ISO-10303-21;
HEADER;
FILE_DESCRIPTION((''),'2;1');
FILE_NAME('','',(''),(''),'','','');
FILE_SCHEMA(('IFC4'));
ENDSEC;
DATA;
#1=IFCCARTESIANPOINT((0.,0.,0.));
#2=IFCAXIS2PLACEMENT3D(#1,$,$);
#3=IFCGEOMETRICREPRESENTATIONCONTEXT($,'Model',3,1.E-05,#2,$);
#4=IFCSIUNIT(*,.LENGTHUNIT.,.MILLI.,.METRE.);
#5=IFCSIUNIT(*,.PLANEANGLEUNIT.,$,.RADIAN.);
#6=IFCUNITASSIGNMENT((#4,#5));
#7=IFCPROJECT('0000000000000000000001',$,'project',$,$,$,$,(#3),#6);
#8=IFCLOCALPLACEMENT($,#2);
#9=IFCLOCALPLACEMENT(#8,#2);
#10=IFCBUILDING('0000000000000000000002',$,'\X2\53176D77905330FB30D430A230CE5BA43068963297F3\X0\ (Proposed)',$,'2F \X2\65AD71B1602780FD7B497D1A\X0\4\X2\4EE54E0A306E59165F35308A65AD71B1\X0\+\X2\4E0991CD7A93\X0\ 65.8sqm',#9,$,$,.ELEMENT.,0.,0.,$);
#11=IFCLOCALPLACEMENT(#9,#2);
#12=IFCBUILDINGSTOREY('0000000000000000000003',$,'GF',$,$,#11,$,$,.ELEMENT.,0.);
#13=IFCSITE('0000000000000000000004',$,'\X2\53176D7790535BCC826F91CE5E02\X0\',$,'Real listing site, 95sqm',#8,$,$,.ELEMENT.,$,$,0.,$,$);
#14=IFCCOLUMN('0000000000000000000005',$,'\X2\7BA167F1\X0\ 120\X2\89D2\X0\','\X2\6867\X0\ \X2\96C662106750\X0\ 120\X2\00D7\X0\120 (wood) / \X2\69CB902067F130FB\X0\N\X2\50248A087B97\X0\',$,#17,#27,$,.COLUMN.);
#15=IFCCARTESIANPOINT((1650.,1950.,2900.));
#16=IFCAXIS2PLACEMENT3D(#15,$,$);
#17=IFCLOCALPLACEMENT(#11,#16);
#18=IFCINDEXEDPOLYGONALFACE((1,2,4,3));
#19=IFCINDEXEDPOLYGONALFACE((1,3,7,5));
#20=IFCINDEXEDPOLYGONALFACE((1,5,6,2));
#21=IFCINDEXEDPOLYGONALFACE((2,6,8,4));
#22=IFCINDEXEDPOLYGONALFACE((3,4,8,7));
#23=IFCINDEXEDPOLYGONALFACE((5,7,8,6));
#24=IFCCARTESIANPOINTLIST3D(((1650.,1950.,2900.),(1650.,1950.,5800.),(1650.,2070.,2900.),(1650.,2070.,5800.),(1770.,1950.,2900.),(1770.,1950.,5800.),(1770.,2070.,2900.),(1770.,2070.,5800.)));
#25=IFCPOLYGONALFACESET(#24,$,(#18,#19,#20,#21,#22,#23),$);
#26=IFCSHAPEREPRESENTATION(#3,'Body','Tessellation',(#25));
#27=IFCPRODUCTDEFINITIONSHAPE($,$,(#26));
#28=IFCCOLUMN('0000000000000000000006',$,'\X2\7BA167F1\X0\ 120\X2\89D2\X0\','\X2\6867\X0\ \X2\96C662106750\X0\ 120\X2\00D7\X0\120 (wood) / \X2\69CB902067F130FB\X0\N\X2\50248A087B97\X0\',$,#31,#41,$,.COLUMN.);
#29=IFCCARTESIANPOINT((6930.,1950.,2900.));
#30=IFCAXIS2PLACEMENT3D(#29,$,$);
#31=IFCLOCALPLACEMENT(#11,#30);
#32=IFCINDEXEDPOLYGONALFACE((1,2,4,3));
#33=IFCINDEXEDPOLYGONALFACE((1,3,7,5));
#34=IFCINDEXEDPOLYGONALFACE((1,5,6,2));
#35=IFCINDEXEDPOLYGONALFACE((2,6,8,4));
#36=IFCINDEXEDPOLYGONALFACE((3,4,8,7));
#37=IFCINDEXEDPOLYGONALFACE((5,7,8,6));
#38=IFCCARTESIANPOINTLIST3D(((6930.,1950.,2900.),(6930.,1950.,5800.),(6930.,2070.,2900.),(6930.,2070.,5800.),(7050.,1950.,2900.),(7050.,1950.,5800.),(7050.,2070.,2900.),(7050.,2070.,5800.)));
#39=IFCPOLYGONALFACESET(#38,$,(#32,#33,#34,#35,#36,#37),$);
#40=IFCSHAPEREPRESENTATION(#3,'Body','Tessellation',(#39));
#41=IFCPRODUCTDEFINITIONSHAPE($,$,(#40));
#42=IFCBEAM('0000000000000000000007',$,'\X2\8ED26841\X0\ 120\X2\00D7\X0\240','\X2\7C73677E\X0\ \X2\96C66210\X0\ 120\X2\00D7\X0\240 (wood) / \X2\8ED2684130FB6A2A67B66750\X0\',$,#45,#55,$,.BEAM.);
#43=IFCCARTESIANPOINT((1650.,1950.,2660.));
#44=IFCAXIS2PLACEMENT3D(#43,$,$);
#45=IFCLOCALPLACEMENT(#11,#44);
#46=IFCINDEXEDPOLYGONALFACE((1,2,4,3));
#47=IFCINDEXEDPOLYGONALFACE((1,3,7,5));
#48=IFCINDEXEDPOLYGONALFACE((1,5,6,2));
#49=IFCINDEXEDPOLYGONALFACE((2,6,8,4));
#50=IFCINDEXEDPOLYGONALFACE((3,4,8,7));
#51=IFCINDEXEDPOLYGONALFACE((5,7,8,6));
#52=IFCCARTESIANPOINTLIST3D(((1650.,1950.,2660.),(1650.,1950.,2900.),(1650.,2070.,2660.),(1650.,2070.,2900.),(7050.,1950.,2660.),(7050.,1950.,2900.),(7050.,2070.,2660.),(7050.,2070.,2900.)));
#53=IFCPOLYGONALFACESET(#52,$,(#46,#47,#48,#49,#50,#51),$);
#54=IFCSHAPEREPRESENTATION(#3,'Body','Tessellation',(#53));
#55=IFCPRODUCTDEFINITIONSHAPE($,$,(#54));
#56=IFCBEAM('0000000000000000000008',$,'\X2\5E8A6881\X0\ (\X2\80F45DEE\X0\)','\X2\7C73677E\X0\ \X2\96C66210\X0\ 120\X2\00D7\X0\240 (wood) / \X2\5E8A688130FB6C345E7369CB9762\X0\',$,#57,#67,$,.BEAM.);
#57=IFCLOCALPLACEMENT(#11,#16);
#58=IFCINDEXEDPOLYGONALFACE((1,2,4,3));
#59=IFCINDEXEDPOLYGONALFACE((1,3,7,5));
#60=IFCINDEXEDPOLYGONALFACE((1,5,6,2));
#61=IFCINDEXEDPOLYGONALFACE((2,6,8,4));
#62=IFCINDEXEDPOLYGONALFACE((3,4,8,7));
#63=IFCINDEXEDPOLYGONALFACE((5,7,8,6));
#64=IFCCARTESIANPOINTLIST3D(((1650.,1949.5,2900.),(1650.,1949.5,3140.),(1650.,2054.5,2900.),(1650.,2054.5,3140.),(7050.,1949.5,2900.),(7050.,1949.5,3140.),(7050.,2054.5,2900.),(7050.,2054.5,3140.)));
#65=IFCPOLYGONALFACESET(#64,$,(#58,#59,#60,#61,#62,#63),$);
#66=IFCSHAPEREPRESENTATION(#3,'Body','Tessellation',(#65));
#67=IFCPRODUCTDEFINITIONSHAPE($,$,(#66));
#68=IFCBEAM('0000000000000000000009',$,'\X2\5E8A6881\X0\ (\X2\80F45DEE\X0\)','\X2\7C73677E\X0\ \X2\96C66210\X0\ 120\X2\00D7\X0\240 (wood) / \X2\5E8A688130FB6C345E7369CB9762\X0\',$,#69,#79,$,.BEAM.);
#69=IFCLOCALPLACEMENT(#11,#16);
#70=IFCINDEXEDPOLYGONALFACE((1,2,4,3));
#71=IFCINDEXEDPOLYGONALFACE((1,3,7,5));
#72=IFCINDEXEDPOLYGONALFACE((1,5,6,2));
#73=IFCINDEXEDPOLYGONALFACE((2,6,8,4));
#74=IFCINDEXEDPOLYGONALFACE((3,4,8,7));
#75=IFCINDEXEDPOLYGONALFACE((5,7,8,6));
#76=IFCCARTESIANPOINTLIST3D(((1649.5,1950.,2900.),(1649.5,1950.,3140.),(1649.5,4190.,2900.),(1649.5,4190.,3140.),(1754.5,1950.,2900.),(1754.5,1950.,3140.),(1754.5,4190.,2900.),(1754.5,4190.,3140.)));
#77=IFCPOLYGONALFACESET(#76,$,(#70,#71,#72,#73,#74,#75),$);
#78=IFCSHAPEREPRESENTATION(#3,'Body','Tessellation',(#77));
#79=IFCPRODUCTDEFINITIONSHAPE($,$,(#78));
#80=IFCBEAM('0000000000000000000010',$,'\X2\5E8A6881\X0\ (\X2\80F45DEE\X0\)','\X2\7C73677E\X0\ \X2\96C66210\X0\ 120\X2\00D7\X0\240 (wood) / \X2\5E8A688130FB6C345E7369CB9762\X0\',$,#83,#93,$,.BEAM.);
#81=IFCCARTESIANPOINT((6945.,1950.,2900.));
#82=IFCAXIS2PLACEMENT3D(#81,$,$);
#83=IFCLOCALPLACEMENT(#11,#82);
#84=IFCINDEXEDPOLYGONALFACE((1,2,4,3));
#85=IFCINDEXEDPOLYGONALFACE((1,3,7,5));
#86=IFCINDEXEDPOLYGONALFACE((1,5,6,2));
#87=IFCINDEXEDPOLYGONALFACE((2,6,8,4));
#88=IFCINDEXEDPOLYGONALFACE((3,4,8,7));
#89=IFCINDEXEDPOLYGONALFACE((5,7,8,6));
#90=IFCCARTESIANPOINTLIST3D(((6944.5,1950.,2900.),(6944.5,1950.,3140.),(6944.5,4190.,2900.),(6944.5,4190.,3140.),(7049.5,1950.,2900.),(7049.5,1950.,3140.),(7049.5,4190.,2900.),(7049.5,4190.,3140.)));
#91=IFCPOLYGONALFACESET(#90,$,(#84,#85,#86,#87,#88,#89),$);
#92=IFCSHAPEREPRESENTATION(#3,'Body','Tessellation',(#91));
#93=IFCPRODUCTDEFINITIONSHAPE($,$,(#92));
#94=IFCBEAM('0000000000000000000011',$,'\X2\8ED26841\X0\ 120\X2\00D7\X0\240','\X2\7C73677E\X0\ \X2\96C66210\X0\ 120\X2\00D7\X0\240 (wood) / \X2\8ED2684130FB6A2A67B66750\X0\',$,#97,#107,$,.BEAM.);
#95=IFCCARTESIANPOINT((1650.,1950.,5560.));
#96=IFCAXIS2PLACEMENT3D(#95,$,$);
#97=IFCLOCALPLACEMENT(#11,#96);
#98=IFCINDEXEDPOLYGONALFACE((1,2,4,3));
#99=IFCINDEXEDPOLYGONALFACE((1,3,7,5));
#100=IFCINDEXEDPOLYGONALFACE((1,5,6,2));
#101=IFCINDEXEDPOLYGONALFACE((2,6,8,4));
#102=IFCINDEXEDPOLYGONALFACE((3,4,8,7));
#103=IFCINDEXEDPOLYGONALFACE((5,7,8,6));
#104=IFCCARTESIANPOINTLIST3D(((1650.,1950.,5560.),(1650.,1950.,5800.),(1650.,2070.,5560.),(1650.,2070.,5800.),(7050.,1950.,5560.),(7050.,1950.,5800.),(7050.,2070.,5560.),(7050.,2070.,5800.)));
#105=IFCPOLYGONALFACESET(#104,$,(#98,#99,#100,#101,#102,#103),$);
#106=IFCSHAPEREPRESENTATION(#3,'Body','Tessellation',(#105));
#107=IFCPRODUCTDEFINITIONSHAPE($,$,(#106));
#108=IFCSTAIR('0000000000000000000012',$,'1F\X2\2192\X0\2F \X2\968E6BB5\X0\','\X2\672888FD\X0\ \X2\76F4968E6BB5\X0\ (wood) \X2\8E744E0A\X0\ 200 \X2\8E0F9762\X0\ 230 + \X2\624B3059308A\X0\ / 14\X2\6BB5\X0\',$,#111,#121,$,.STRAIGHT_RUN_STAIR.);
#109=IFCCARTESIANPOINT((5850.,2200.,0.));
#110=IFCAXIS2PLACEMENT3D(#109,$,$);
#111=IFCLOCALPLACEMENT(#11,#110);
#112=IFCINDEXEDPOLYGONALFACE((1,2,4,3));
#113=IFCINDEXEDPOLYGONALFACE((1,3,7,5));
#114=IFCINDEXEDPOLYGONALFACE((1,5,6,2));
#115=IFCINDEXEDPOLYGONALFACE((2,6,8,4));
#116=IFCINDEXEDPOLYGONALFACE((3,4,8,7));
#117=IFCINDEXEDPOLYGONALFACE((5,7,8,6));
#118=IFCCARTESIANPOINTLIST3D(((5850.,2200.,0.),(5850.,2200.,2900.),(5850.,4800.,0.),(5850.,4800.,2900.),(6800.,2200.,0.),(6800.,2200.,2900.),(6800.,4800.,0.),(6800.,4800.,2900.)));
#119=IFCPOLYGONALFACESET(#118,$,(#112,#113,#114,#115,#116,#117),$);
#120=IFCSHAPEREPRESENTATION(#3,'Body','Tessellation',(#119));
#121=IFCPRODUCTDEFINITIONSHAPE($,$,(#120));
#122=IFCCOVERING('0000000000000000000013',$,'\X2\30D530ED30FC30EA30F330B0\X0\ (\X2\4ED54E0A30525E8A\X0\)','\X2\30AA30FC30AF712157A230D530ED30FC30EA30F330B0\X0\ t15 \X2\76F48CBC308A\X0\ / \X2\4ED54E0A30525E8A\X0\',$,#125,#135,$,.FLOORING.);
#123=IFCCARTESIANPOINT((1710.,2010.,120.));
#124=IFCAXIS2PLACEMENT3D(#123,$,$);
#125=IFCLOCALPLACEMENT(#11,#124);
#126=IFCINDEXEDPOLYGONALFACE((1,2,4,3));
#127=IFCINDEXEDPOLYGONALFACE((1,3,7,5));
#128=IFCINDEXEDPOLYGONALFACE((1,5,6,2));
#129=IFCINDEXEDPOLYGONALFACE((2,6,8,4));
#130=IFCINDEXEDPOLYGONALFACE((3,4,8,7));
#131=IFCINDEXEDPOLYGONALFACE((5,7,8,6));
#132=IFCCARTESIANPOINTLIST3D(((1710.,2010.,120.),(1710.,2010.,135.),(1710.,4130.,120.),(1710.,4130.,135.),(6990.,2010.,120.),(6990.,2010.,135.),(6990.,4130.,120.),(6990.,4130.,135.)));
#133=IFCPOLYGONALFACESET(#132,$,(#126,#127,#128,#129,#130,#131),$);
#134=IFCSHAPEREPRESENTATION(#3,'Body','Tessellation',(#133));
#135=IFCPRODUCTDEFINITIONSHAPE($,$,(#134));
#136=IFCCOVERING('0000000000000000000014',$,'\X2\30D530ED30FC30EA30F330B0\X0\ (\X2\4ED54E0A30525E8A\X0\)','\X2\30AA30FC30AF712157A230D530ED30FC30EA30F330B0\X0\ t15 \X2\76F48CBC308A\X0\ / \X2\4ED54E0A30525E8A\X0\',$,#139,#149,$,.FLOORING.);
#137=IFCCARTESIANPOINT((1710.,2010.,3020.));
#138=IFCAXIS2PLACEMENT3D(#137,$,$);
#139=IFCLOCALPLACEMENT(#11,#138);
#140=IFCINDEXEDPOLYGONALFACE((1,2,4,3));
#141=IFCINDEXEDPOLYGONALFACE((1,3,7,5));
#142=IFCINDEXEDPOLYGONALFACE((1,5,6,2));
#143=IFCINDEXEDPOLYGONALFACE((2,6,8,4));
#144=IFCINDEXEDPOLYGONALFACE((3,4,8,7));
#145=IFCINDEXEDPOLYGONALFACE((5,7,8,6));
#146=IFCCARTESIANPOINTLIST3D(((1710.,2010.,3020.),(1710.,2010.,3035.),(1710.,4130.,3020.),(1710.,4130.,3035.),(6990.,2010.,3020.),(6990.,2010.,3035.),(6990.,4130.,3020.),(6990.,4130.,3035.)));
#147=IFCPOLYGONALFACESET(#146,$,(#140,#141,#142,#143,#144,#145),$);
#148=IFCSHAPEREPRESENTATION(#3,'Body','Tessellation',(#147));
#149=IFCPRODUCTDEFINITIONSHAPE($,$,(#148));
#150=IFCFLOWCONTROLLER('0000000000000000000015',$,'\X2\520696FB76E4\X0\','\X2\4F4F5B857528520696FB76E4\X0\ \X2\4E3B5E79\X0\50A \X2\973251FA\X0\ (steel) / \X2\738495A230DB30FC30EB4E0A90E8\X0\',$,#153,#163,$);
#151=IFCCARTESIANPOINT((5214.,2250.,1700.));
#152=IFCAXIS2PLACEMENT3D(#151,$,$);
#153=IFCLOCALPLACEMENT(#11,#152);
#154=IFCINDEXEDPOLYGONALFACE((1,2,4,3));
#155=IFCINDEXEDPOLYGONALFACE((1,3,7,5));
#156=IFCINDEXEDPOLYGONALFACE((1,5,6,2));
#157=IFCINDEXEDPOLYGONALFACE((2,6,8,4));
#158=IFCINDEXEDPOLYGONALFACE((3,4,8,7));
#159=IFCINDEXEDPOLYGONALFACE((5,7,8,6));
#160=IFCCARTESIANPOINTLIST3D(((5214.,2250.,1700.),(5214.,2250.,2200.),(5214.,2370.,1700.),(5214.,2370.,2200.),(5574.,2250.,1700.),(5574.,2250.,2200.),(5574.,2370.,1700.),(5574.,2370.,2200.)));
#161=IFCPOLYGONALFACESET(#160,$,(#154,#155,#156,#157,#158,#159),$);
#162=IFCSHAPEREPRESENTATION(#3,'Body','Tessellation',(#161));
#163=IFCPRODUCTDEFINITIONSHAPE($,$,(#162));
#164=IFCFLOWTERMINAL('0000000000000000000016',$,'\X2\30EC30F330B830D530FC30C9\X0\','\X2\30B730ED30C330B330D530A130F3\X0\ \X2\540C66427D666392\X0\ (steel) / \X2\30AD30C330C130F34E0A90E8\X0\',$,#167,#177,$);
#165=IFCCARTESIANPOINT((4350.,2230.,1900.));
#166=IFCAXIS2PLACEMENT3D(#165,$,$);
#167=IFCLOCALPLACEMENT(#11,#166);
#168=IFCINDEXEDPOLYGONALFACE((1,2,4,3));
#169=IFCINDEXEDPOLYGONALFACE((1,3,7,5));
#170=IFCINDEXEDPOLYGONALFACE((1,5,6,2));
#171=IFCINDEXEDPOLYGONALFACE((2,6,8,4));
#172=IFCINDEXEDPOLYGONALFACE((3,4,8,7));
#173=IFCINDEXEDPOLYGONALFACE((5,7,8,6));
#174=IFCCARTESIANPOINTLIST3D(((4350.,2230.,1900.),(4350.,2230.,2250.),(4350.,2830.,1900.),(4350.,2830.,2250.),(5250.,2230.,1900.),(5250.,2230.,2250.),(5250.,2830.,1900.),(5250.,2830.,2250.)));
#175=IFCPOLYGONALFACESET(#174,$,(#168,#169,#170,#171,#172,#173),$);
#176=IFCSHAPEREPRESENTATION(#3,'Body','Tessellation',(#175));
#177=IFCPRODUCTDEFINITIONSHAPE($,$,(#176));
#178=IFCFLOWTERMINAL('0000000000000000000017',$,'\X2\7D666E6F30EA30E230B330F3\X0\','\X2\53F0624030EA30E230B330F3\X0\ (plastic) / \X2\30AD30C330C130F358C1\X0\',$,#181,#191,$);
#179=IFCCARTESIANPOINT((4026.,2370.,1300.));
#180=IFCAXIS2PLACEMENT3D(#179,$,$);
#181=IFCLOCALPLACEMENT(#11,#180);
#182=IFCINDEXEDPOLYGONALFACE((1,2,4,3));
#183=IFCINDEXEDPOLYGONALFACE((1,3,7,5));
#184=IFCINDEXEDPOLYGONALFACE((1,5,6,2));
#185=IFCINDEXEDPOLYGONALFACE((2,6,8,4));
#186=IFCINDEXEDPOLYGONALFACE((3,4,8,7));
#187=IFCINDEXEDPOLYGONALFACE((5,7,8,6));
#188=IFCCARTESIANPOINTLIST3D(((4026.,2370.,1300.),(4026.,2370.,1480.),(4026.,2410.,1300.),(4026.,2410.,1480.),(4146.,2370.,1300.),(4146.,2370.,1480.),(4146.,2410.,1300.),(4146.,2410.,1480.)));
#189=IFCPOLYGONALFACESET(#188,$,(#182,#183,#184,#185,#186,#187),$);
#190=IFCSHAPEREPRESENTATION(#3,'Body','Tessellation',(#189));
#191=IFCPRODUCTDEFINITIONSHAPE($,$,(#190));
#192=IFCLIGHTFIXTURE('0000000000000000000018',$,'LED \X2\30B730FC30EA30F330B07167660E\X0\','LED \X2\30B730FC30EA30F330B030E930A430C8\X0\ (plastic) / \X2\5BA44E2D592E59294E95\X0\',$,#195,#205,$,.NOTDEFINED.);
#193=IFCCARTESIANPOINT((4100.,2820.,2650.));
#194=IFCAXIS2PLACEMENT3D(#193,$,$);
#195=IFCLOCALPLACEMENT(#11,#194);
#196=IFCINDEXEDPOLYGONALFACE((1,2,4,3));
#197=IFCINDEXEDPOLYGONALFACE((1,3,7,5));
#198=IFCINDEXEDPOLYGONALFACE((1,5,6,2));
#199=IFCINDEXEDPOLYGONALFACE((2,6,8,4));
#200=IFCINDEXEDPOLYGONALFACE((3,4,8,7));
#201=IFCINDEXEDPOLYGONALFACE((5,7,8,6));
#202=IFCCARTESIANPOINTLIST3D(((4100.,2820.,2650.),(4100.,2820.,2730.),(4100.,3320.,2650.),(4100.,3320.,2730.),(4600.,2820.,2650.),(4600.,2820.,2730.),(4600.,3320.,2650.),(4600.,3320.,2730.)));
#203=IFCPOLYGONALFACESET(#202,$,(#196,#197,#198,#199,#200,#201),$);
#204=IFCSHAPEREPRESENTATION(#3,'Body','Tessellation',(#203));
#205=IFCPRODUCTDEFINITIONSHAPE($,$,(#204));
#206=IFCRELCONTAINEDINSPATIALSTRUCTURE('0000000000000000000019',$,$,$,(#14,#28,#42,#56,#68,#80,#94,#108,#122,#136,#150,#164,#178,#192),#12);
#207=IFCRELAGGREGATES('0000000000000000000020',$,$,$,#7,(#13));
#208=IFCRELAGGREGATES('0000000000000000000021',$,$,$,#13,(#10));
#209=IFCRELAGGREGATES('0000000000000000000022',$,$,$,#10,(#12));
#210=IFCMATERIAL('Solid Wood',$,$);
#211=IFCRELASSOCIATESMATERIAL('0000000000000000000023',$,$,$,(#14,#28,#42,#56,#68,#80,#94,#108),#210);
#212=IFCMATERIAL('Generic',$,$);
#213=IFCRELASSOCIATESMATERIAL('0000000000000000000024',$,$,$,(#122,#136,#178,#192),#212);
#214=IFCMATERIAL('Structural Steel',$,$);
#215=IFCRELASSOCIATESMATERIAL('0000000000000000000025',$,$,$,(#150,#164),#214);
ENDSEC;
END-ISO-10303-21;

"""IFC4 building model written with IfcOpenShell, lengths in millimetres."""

from ifc_helpers import new_model, si_unit, frame, frame_2d, origin, place, context, project, spatial, rectangle, extrude, material, element, save


model = new_model("IFC4")

# Units and contexts
model_context = context("Model", 3, precision=1e-05, world=origin())
ifc_project = project(units=[si_unit("LENGTHUNIT", "METRE", prefix="MILLI"), si_unit("PLANEANGLEUNIT", "RADIAN")], contexts=[model_context])

# Site, building, storey
site_placement = place(None, origin())
site = spatial("IfcSite", under=ifc_project, at=site_placement, Name="北海道富良野市", ObjectType="Real listing site, 95sqm", CompositionType="ELEMENT", RefElevation=0.0)
building_placement = place(site_placement, origin())
building = spatial("IfcBuilding", under=site, at=building_placement, Name="北海道・ピアノ室と防音 (Proposed)", ObjectType="2F 断熱性能等級4以上の外張り断熱+三重窓 65.8sqm", CompositionType="ELEMENT", ElevationOfRefHeight=0.0, ElevationOfTerrain=0.0)
storey_placement = place(building_placement, origin())
storey = spatial("IfcBuildingStorey", under=building, at=storey_placement, Name="GF", CompositionType="ELEMENT", Elevation=0.0)

# Columns
ifc_material_1 = material(Name="Solid Wood")
column_1_placement = place(storey_placement, frame((1650.0, 1950.0, 2900.0)))
element("IfcColumn", 1, at=column_1_placement, inside=storey, material=ifc_material_1, Name="管柱 120角", Description="桧 集成材 120×120 (wood) / 構造柱・N値計算", PredefinedType="COLUMN", context=model_context, shape_type="SweptSolid", body=[
    extrude(rectangle(XDim=120.0, YDim=120.0, at=frame_2d((60.0, 60.0))), frame((1650.0, 1950.0, 2900.0)), (0.0, 0.0, 1.0), 2900.0),
])
column_2_placement = place(storey_placement, frame((6930.0, 1950.0, 2900.0)))
element("IfcColumn", 2, at=column_2_placement, inside=storey, material=ifc_material_1, Name="管柱 120角", Description="桧 集成材 120×120 (wood) / 構造柱・N値計算", PredefinedType="COLUMN", context=model_context, shape_type="SweptSolid", body=[
    extrude(rectangle(XDim=120.0, YDim=120.0, at=frame_2d((60.0, 60.0))), frame((6930.0, 1950.0, 2900.0)), (0.0, 0.0, 1.0), 2900.0),
])

# Beams
beam_1_placement = place(storey_placement, frame((1650.0, 1950.0, 2660.0)))
element("IfcBeam", 3, at=beam_1_placement, inside=storey, material=ifc_material_1, Name="軒桁 120×240", Description="米松 集成 120×240 (wood) / 軒桁・横架材", PredefinedType="BEAM", context=model_context, shape_type="SweptSolid", body=[
    extrude(rectangle(XDim=5400.0, YDim=120.0, at=frame_2d((2700.0, 60.0))), frame((1650.0, 1950.0, 2660.0)), (0.0, 0.0, 1.0), 240.0),
])
beam_2_placement = place(storey_placement, frame((1650.0, 1950.0, 2900.0)))
element("IfcBeam", 4, at=beam_2_placement, inside=storey, material=ifc_material_1, Name="床梁 (胴差)", Description="米松 集成 120×240 (wood) / 床梁・水平構面", PredefinedType="BEAM", context=model_context, shape_type="SweptSolid", body=[
    extrude(rectangle(XDim=5400.0, YDim=105.0, at=frame_2d((2700.0, 52.0))), frame((1650.0, 1950.0, 2900.0)), (0.0, 0.0, 1.0), 240.0),
])
beam_3_placement = place(storey_placement, frame((1650.0, 1950.0, 2900.0)))
element("IfcBeam", 5, at=beam_3_placement, inside=storey, material=ifc_material_1, Name="床梁 (胴差)", Description="米松 集成 120×240 (wood) / 床梁・水平構面", PredefinedType="BEAM", context=model_context, shape_type="SweptSolid", body=[
    extrude(rectangle(XDim=105.0, YDim=2240.0, at=frame_2d((52.0, 1120.0))), frame((1650.0, 1950.0, 2900.0)), (0.0, 0.0, 1.0), 240.0),
])
beam_4_placement = place(storey_placement, frame((6945.0, 1950.0, 2900.0)))
element("IfcBeam", 6, at=beam_4_placement, inside=storey, material=ifc_material_1, Name="床梁 (胴差)", Description="米松 集成 120×240 (wood) / 床梁・水平構面", PredefinedType="BEAM", context=model_context, shape_type="SweptSolid", body=[
    extrude(rectangle(XDim=105.0, YDim=2240.0, at=frame_2d((52.0, 1120.0))), frame((6945.0, 1950.0, 2900.0)), (0.0, 0.0, 1.0), 240.0),
])
beam_5_placement = place(storey_placement, frame((1650.0, 1950.0, 5560.0)))
element("IfcBeam", 7, at=beam_5_placement, inside=storey, material=ifc_material_1, Name="軒桁 120×240", Description="米松 集成 120×240 (wood) / 軒桁・横架材", PredefinedType="BEAM", context=model_context, shape_type="SweptSolid", body=[
    extrude(rectangle(XDim=5400.0, YDim=120.0, at=frame_2d((2700.0, 60.0))), frame((1650.0, 1950.0, 5560.0)), (0.0, 0.0, 1.0), 240.0),
])

# Stair
stair_placement = place(storey_placement, frame((5850.0, 2200.0, 0.0)))
element("IfcStair", 8, at=stair_placement, inside=storey, material=ifc_material_1, Name="1F→2F 階段", Description="木製 直階段 (wood) 蹴上 200 踏面 230 + 手すり / 14段", PredefinedType="STRAIGHT_RUN_STAIR", context=model_context, shape_type="SweptSolid", body=[
    extrude(rectangle(XDim=950.0, YDim=2600.0, at=frame_2d((475.0, 1300.0))), frame((5850.0, 2200.0, 0.0)), (0.0, 0.0, 1.0), 2900.0),
])

# Coverings
ifc_material_2 = material(Name="Generic")
covering_1_placement = place(storey_placement, frame((1710.0, 2010.0, 120.0)))
element("IfcCovering", 9, at=covering_1_placement, inside=storey, material=ifc_material_2, Name="フローリング (仕上げ床)", Description="オーク無垢フローリング t15 直貼り / 仕上げ床", PredefinedType="FLOORING", context=model_context, shape_type="SweptSolid", body=[
    extrude(rectangle(XDim=5280.0, YDim=2120.0, at=frame_2d((2640.0, 1060.0))), frame((1710.0, 2010.0, 120.0)), (0.0, 0.0, 1.0), 15.0),
])
covering_2_placement = place(storey_placement, frame((1710.0, 2010.0, 3020.0)))
element("IfcCovering", 10, at=covering_2_placement, inside=storey, material=ifc_material_2, Name="フローリング (仕上げ床)", Description="オーク無垢フローリング t15 直貼り / 仕上げ床", PredefinedType="FLOORING", context=model_context, shape_type="SweptSolid", body=[
    extrude(rectangle(XDim=5280.0, YDim=2120.0, at=frame_2d((2640.0, 1060.0))), frame((1710.0, 2010.0, 3020.0)), (0.0, 0.0, 1.0), 15.0),
])

# Flow controller
ifc_material_3 = material(Name="Structural Steel")
flow_controller_placement = place(storey_placement, frame((5214.0, 2250.0, 1700.0)))
element("IfcFlowController", 11, at=flow_controller_placement, inside=storey, material=ifc_material_3, Name="分電盤", Description="住宅用分電盤 主幹50A 露出 (steel) / 玄関ホール上部", context=model_context, shape_type="SweptSolid", body=[
    extrude(rectangle(XDim=360.0, YDim=120.0, at=frame_2d((180.0, 60.0))), frame((5214.0, 2250.0, 1700.0)), (0.0, 0.0, 1.0), 500.0),
])

# Flow terminals
flow_terminal_1_placement = place(storey_placement, frame((4350.0, 2230.0, 1900.0)))
element("IfcFlowTerminal", 12, at=flow_terminal_1_placement, inside=storey, material=ifc_material_3, Name="レンジフード", Description="シロッコファン 同時給排 (steel) / キッチン上部", context=model_context, shape_type="SweptSolid", body=[
    extrude(rectangle(XDim=900.0, YDim=600.0, at=frame_2d((450.0, 300.0))), frame((4350.0, 2230.0, 1900.0)), (0.0, 0.0, 1.0), 350.0),
])
flow_terminal_2_placement = place(storey_placement, frame((4026.0, 2370.0, 1300.0)))
element("IfcFlowTerminal", 13, at=flow_terminal_2_placement, inside=storey, material=ifc_material_2, Name="給湯リモコン", Description="台所リモコン (plastic) / キッチン壁", context=model_context, shape_type="SweptSolid", body=[
    extrude(rectangle(XDim=120.0, YDim=40.0, at=frame_2d((60.0, 20.0))), frame((4026.0, 2370.0, 1300.0)), (0.0, 0.0, 1.0), 180.0),
])

# Light fixture
light_fixture_1_placement = place(storey_placement, frame((4100.0, 2820.0, 2650.0)))
element("IfcLightFixture", 14, at=light_fixture_1_placement, inside=storey, material=ifc_material_2, Name="LED シーリング照明", Description="LED シーリングライト (plastic) / 室中央天井", PredefinedType="NOTDEFINED", context=model_context, shape_type="SweptSolid", body=[
    extrude(rectangle(XDim=500.0, YDim=500.0, at=frame_2d((250.0, 250.0))), frame((4100.0, 2820.0, 2650.0)), (0.0, 0.0, 1.0), 80.0),
])

save(model, "model.ifc")
